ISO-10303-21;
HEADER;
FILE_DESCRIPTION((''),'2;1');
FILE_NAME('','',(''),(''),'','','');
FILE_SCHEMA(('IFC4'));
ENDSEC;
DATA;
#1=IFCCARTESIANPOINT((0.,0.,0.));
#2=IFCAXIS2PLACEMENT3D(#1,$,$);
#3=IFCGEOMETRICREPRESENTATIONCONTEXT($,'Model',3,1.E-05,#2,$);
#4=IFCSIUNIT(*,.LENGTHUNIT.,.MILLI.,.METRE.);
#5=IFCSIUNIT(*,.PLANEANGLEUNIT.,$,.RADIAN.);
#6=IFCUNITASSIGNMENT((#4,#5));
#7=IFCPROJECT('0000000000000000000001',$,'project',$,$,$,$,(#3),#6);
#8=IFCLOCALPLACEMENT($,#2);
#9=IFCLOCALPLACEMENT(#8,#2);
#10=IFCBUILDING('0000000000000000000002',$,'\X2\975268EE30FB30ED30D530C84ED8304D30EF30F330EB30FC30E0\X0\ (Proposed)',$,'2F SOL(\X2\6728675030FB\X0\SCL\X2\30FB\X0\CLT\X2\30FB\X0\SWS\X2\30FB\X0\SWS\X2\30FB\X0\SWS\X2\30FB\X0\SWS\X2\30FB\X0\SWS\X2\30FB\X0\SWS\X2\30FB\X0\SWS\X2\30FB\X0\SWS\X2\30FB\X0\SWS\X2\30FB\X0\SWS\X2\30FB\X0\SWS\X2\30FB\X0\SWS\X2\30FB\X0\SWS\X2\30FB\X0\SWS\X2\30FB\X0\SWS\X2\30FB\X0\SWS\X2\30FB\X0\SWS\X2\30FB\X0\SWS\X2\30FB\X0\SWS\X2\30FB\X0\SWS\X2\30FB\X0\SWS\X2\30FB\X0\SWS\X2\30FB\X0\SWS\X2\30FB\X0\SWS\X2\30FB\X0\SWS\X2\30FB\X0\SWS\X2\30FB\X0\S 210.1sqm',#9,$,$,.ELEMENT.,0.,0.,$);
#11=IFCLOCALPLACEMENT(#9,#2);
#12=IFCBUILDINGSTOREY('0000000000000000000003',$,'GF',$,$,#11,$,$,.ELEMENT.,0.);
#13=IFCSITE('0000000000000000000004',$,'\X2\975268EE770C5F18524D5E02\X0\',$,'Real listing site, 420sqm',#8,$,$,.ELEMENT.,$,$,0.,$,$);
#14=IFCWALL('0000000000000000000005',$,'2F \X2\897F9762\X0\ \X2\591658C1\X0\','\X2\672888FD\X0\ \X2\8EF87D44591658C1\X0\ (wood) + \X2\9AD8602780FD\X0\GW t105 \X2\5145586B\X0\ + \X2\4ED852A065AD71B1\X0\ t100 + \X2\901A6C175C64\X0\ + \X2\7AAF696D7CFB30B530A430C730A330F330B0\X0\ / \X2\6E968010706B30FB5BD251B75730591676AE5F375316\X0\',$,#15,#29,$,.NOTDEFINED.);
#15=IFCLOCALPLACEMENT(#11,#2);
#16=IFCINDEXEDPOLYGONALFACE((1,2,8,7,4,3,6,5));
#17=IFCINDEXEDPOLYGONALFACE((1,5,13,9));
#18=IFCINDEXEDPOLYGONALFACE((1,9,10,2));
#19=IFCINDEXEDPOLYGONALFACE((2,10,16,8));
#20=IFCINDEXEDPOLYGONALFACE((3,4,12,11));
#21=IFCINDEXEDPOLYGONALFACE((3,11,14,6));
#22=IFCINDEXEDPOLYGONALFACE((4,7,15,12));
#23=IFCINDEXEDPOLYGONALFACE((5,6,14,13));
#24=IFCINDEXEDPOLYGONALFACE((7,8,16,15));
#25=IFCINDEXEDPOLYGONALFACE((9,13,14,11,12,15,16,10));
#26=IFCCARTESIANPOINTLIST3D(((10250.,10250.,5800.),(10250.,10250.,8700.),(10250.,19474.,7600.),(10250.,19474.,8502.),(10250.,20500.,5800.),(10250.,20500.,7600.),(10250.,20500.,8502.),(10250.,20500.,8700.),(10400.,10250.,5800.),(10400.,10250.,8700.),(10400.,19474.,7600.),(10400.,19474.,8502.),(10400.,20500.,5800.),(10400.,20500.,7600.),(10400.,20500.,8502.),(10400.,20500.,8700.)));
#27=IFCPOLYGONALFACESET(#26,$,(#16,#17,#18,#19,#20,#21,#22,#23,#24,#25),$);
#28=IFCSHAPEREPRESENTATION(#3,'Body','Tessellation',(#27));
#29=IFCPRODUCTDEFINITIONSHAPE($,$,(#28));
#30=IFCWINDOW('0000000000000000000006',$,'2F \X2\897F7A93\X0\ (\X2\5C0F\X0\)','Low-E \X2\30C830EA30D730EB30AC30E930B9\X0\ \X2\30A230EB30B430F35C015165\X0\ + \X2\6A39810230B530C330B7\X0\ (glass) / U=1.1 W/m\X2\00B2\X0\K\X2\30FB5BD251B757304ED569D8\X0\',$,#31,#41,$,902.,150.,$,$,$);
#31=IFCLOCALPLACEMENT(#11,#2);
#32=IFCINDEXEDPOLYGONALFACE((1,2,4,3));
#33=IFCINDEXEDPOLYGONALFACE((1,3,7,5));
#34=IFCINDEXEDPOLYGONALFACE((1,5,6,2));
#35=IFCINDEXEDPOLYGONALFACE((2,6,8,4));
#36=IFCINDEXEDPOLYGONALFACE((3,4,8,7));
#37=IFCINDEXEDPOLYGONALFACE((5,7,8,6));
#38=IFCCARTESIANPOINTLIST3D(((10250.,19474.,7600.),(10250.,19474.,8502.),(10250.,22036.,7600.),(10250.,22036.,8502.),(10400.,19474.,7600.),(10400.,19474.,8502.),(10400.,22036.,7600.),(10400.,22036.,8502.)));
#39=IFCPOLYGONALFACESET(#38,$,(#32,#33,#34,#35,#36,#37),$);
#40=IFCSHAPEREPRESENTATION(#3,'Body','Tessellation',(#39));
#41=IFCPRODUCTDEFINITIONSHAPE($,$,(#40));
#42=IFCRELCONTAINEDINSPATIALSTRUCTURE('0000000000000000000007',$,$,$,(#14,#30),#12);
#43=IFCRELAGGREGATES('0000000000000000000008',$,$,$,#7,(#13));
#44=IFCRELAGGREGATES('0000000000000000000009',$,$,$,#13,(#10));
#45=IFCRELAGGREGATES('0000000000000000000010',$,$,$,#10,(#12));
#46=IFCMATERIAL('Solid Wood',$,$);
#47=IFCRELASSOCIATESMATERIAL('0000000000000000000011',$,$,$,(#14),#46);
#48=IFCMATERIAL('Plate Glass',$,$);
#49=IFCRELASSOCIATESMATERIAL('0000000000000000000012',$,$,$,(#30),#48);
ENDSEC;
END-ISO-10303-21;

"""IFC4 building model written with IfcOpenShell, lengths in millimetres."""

from ifc_helpers import new_model, si_unit, frame, frame_2d, origin, place, context, project, spatial, rectangle, extrude, material, element, fill, save


model = new_model("IFC4")

# Units and contexts
model_context = context("Model", 3, precision=1e-05, world=origin())
ifc_project = project(units=[si_unit("LENGTHUNIT", "METRE", prefix="MILLI"), si_unit("PLANEANGLEUNIT", "RADIAN")], contexts=[model_context])

# Site, building, storey
site_placement = place(None, origin())
site = spatial("IfcSite", under=ifc_project, at=site_placement, Name="青森県弘前市", ObjectType="Real listing site, 420sqm", CompositionType="ELEMENT", RefElevation=0.0)
building_placement = place(site_placement, origin())
building = spatial("IfcBuilding", under=site, at=building_placement, Name="青森・ロフト付きワンルーム (Proposed)", ObjectType="2F SOL(木材・SCL・CLT・SWS・SWS・SWS・SWS・SWS・SWS・SWS・SWS・SWS・SWS・SWS・SWS・SWS・SWS・SWS・SWS・SWS・SWS・SWS・SWS・SWS・SWS・SWS・SWS・SWS・SWS・S 210.1sqm", CompositionType="ELEMENT", ElevationOfRefHeight=0.0, ElevationOfTerrain=0.0)
storey_placement = place(building_placement, origin())
storey = spatial("IfcBuildingStorey", under=building, at=storey_placement, Name="GF", CompositionType="ELEMENT", Elevation=0.0)

# Shared definitions
ifc_material_1 = material(Name="Solid Wood")

# Shared definitions
ifc_material_2 = material(Name="Plate Glass")

# Wall, opening, window
wall_1_placement = place(storey_placement, frame((5125.0, 5125.0, 2900.0)))
wall_1 = element("IfcWall", 1, at=wall_1_placement, inside=storey, material=ifc_material_1, Name="2F 西面 外壁", Description="木製 軸組外壁 (wood) + 高性能GW t105 充填 + 付加断熱 t100 + 通気層 + 窯業系サイディング / 準耐火・寒冷地外皮強化", PredefinedType="NOTDEFINED", context=model_context, shape_type="SweptSolid", body=[
    extrude(rectangle(XDim=150.0, YDim=10250.0, at=frame_2d((75.0, 5125.0))), frame((5125.0, 5125.0, 2900.0)), (0.0, 0.0, 1.0), 2900.0),
])
opening_1_placement = place(storey_placement, frame((5125.0, 9737.0, 3800.0)))
opening_1 = element("IfcOpeningElement", 2, at=opening_1_placement, cuts=wall_1, PredefinedType="NOTDEFINED", context=model_context, shape_type="SweptSolid", body=[
    extrude(rectangle(XDim=150.0, YDim=2562.0, at=frame_2d((75.0, 1281.0))), frame((5125.0, 9737.0, 3800.0)), (0.0, 0.0, 1.0), 902.0),
])
window_1_placement = place(storey_placement, frame((5125.0, 9737.0, 3800.0)))
window_1 = element("IfcWindow", 3, at=window_1_placement, inside=storey, material=ifc_material_2, Name="2F 西窓 (小)", Description="Low-E トリプルガラス アルゴン封入 + 樹脂サッシ (glass) / U=1.1 W/m²K・寒冷地仕様", OverallHeight=902.0, OverallWidth=150.0, context=model_context, shape_type="SweptSolid", body=[
    extrude(rectangle(XDim=150.0, YDim=2562.0, at=frame_2d((75.0, 1281.0))), frame((5125.0, 9737.0, 3800.0)), (0.0, 0.0, 1.0), 902.0),
])
fill(opening_1, window_1)

save(model, "model.ifc")
